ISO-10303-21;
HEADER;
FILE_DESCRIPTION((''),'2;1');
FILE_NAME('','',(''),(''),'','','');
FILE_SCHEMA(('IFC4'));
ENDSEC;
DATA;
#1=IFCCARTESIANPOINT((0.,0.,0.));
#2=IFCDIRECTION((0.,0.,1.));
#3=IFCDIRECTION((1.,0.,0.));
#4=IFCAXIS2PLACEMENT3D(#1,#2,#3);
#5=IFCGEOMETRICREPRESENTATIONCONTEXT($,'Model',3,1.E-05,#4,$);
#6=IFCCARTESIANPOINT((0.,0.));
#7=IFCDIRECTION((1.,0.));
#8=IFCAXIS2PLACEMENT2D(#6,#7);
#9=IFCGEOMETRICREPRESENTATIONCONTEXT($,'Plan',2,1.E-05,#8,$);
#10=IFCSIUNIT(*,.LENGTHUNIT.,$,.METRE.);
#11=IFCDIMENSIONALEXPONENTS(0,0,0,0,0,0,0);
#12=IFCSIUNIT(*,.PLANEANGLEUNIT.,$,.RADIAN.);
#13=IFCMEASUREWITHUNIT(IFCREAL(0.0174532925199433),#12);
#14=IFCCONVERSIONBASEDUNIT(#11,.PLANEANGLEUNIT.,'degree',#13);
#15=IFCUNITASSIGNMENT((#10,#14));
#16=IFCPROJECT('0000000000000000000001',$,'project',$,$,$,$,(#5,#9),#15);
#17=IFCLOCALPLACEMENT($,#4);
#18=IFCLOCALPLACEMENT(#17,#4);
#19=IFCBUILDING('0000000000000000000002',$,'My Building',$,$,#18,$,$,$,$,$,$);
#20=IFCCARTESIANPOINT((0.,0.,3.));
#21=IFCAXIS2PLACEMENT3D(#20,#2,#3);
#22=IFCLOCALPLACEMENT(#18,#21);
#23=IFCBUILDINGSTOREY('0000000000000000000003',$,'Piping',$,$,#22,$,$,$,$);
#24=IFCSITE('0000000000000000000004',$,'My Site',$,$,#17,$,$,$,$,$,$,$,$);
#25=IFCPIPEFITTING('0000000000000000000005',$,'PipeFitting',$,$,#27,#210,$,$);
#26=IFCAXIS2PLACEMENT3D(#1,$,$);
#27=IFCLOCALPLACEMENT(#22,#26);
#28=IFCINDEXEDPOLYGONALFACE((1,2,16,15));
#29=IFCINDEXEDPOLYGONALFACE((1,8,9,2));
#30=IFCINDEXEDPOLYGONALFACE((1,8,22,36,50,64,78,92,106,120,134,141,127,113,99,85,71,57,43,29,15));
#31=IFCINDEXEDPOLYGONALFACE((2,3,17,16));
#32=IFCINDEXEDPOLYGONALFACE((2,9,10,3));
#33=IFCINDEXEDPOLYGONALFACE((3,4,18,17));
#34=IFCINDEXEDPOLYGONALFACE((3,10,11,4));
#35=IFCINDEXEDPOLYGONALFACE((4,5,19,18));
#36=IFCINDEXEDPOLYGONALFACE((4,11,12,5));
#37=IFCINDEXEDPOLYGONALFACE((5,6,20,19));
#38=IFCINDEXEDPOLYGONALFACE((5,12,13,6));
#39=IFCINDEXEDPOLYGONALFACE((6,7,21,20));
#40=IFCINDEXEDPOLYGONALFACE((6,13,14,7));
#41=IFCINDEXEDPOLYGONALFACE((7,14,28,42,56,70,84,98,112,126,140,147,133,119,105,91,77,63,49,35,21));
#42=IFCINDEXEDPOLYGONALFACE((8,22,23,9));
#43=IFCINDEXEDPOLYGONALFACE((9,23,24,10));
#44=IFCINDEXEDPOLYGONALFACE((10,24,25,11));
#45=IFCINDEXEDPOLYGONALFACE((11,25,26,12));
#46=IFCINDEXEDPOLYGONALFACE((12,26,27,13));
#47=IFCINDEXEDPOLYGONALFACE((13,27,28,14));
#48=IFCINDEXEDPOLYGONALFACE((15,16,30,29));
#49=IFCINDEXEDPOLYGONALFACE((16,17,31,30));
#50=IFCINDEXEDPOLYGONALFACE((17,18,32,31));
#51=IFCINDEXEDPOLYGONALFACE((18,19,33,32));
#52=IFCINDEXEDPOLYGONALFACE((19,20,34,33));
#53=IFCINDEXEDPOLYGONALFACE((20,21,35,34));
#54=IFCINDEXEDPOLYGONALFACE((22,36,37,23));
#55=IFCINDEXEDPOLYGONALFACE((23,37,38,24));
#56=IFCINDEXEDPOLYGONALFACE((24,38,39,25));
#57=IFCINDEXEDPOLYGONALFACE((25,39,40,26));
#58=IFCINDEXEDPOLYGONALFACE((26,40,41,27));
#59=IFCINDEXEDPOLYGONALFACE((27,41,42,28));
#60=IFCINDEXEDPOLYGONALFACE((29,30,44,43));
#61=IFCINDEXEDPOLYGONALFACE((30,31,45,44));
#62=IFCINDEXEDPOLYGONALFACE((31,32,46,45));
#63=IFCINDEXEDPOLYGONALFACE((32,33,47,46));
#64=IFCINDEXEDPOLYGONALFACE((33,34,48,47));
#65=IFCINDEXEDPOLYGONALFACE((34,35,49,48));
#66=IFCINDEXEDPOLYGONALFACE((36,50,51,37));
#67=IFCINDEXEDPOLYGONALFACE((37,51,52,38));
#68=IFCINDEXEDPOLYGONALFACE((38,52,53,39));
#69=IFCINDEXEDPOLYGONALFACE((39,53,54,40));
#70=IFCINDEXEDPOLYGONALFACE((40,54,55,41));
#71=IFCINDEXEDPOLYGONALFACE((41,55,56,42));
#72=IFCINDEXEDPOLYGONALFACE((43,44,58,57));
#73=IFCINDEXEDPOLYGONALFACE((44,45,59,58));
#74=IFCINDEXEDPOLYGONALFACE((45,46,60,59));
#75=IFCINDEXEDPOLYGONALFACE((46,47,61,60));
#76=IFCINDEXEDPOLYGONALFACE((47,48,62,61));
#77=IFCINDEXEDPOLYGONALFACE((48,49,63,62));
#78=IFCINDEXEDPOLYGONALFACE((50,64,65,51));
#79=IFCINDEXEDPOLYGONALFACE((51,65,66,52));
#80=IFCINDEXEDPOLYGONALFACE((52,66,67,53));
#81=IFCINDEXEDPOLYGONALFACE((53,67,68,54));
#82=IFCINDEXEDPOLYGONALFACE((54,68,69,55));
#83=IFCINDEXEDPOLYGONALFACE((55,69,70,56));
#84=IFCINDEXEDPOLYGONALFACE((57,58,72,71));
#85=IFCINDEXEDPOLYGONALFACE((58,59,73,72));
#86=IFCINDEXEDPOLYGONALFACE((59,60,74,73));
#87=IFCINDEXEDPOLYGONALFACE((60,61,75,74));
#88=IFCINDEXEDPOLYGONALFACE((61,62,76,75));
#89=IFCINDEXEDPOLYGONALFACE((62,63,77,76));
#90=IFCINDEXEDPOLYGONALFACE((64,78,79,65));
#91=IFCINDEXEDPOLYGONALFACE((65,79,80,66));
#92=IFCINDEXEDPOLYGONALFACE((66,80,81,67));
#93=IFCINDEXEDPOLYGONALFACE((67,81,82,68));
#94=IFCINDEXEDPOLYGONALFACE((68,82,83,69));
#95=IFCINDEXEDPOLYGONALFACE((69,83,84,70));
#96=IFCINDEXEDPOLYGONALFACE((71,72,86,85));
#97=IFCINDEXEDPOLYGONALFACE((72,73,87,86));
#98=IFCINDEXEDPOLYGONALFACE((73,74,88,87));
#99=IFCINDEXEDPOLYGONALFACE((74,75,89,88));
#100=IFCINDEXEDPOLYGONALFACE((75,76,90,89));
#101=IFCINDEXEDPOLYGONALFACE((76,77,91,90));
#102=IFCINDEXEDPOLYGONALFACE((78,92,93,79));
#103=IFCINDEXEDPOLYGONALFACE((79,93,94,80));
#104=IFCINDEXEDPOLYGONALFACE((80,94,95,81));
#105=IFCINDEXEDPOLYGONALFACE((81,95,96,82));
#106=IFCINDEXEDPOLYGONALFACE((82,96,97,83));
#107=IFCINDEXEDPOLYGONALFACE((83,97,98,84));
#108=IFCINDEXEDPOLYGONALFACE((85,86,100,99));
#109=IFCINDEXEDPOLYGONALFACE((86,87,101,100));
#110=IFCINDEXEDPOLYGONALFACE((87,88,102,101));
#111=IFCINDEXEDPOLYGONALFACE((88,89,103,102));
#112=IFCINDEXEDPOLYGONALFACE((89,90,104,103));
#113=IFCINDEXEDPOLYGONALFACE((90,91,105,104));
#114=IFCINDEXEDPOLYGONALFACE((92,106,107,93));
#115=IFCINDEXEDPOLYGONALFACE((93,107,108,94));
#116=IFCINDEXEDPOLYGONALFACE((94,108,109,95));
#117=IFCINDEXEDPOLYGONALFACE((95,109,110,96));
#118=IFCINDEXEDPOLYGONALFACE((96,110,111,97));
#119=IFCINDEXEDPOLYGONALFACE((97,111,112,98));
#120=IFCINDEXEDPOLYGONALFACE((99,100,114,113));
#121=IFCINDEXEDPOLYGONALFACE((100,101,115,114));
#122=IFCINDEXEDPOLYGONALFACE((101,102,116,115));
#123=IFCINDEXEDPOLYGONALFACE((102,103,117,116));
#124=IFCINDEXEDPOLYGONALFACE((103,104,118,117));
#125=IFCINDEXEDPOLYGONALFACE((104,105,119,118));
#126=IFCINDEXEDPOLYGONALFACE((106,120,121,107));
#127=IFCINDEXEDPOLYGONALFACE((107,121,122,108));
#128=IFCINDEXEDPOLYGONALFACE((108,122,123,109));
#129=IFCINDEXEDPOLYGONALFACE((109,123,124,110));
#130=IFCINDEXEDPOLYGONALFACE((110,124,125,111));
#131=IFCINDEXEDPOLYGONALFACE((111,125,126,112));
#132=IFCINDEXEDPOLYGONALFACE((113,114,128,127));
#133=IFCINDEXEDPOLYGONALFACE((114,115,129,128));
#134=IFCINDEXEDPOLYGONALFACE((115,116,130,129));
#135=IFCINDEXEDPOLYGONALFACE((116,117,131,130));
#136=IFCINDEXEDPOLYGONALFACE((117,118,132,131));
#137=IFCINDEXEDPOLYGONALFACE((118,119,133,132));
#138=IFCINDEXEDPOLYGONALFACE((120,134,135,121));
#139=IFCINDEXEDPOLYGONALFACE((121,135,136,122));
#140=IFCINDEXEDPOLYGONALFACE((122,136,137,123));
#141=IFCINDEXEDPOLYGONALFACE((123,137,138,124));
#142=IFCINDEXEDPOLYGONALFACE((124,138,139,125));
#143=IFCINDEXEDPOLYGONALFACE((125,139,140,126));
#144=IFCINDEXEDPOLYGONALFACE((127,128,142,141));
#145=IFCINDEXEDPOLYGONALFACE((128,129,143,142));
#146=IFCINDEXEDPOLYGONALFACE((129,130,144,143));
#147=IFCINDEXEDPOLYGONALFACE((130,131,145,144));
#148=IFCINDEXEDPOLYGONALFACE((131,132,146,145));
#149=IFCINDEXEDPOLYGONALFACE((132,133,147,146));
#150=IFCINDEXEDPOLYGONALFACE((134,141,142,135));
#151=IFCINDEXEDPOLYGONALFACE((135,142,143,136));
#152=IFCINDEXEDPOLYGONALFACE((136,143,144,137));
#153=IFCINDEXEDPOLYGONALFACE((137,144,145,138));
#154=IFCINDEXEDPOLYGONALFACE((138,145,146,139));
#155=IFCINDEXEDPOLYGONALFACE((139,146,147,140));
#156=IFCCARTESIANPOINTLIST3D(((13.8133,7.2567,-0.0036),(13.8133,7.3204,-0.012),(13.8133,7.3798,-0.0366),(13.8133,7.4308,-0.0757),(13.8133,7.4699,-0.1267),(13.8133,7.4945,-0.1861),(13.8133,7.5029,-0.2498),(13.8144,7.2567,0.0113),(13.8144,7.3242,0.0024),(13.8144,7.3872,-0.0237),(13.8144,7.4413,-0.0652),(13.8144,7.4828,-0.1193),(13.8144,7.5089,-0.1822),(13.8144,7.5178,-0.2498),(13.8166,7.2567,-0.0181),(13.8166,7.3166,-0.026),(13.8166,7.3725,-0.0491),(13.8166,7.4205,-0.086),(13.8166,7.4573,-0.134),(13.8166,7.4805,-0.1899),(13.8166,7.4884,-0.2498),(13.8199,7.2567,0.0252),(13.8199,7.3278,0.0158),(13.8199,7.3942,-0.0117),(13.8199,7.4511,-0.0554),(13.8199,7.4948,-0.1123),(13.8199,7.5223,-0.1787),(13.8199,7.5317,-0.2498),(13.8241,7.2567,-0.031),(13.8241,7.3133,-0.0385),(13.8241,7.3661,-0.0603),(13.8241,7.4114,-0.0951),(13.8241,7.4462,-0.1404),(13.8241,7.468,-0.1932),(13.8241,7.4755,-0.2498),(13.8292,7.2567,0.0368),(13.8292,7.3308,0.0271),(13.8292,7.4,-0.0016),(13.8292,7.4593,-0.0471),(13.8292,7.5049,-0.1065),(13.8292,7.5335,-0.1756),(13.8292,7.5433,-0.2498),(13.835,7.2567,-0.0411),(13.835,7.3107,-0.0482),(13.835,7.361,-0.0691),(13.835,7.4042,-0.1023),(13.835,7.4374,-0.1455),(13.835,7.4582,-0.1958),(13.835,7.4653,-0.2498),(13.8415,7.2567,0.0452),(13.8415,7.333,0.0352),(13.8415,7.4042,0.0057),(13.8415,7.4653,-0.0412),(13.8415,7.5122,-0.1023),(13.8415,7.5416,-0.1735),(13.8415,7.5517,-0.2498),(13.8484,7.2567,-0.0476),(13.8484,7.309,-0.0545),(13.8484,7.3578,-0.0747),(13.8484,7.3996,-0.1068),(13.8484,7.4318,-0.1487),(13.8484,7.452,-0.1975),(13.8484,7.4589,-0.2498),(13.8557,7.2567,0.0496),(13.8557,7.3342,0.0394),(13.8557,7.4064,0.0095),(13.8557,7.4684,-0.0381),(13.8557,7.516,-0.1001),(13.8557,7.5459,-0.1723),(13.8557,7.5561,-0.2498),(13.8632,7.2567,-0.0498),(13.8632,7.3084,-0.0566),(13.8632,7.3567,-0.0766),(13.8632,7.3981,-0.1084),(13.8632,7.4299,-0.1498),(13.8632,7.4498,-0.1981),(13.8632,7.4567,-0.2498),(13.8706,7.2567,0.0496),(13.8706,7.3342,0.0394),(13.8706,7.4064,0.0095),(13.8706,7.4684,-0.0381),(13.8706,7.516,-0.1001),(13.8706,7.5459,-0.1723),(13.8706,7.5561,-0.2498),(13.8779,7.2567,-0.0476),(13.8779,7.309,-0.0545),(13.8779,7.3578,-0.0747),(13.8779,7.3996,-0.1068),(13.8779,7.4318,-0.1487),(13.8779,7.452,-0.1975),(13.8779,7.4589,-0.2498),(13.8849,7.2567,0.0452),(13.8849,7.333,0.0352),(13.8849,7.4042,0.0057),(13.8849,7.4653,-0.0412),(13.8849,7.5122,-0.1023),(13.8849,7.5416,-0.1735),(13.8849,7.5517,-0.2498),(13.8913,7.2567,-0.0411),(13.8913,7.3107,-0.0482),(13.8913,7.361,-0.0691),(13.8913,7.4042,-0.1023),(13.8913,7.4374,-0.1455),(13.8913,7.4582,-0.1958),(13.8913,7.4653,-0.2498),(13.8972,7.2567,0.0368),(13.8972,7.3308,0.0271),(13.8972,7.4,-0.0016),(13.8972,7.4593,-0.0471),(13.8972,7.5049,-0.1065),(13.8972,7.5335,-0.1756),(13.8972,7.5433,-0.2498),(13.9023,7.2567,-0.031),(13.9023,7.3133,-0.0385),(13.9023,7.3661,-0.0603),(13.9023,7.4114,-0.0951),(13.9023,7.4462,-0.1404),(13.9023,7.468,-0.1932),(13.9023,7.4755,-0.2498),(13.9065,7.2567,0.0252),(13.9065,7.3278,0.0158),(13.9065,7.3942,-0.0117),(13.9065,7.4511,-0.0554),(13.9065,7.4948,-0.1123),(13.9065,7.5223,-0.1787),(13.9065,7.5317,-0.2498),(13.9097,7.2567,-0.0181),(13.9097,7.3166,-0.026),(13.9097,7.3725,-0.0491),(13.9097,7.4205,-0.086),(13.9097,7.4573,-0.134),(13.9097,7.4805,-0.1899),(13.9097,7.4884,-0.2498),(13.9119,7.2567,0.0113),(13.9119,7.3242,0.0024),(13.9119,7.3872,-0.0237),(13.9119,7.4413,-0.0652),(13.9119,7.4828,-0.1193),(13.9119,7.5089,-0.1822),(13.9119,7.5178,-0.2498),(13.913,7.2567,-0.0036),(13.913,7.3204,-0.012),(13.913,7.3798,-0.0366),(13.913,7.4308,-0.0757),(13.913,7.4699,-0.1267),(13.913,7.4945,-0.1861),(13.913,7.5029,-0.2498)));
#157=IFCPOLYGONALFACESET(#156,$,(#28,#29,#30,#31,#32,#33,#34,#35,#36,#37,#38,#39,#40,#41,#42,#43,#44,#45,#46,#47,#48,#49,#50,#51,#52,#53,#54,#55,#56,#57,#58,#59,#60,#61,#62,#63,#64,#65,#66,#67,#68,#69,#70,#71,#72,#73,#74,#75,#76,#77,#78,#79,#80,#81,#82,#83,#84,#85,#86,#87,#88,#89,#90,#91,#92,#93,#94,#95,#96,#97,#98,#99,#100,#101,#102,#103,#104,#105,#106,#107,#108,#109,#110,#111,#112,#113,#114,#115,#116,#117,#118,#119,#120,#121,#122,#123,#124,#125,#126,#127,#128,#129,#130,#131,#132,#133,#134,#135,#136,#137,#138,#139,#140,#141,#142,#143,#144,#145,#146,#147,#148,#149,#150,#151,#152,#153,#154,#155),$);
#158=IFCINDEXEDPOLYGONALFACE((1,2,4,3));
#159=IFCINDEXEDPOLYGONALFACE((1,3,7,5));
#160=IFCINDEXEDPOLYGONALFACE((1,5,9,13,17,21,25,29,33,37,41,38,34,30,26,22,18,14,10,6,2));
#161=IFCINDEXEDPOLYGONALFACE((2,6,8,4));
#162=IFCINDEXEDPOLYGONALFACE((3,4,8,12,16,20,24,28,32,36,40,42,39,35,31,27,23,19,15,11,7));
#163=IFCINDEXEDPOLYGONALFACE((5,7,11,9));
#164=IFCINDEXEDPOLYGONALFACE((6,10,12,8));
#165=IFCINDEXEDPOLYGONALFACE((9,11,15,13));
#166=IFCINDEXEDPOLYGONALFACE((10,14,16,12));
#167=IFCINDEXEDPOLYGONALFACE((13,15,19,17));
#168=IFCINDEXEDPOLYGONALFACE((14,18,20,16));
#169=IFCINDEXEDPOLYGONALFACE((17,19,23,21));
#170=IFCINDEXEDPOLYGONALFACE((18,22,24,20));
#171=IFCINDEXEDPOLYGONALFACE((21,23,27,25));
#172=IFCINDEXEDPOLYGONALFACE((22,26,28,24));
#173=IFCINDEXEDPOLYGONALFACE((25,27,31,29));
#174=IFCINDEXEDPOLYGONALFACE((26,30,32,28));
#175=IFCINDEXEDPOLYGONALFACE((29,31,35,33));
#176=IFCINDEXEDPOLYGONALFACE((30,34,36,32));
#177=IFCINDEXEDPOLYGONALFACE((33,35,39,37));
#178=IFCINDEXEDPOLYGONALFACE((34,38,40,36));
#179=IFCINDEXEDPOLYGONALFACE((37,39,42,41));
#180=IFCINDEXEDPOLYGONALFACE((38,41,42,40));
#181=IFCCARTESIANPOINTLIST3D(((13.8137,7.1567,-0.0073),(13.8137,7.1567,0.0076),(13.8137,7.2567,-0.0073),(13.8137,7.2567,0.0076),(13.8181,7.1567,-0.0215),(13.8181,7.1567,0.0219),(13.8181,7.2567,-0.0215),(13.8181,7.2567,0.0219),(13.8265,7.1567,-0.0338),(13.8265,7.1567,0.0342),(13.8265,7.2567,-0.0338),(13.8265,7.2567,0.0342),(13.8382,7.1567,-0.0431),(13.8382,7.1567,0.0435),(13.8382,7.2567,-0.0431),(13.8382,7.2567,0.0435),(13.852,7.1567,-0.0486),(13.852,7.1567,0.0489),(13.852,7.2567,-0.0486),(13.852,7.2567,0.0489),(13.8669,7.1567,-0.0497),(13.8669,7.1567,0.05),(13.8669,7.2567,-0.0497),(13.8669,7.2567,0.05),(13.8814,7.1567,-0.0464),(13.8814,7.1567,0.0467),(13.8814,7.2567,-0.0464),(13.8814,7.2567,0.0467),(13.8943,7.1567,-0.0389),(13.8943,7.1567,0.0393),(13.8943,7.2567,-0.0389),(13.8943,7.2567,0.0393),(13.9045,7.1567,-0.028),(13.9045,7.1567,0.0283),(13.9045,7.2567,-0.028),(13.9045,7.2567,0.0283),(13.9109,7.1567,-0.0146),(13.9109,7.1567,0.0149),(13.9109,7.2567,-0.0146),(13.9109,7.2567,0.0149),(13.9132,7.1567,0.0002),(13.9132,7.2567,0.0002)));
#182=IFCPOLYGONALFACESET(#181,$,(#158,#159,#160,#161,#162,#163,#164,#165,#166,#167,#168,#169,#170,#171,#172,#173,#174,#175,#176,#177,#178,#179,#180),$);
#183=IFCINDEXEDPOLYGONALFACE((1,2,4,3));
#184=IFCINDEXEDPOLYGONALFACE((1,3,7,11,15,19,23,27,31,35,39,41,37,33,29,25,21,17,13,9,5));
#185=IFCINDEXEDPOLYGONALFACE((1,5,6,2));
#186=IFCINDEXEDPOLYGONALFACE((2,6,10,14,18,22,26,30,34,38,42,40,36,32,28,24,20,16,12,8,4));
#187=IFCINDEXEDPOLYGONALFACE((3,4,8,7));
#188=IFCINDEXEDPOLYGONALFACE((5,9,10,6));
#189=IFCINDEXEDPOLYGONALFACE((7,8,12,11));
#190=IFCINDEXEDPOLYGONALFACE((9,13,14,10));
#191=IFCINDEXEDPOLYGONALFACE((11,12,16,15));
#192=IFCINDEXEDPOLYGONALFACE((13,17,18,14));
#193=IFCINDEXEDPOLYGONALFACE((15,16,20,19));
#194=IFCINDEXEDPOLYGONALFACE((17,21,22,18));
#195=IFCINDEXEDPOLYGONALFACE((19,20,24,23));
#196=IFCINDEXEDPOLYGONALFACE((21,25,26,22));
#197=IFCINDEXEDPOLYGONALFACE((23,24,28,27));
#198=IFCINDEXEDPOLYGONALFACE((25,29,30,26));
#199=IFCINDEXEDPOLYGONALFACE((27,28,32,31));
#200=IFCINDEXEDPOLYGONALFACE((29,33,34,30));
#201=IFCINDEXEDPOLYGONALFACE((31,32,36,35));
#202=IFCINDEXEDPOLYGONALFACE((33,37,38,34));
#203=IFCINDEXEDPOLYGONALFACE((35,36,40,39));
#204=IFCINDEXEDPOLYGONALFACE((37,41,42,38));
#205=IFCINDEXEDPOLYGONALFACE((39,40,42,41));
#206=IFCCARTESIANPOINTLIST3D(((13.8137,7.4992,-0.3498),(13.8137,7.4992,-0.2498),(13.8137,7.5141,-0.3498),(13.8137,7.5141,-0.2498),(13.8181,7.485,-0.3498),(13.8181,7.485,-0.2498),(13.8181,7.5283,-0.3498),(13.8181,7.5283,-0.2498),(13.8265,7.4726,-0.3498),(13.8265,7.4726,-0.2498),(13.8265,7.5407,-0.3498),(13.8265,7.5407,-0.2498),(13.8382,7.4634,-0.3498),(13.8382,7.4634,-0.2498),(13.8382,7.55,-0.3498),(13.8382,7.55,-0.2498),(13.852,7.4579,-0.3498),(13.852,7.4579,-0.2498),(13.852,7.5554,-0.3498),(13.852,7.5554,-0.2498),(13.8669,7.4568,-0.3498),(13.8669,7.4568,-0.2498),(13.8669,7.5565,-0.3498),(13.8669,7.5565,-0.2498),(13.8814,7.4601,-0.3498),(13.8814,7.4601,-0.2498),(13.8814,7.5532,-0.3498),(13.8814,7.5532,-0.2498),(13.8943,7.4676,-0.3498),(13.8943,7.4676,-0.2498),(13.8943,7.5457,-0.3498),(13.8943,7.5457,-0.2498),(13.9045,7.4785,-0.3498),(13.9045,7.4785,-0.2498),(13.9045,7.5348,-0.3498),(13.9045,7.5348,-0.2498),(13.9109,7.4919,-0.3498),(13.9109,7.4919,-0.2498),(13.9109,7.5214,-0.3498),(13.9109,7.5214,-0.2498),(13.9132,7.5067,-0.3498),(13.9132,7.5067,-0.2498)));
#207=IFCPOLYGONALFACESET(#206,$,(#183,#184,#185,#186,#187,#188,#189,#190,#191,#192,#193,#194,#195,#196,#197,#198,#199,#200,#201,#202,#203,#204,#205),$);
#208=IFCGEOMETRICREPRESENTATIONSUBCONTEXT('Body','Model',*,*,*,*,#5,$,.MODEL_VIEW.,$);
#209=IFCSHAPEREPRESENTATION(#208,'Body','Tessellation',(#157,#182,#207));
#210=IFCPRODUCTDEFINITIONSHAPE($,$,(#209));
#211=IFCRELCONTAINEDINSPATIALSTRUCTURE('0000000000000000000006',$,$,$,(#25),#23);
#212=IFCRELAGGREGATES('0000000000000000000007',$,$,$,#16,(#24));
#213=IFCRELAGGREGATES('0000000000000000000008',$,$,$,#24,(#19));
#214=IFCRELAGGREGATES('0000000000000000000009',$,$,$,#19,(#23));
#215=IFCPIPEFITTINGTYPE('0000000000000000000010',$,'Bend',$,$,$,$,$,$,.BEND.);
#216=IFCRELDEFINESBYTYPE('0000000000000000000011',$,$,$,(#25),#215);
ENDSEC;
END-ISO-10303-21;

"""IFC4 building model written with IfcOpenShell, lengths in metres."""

from ifc_helpers import new_model, entity, si_unit, converted_unit, frame, origin_with_axes, origin_2d_with_axis, place, context, subcontext, project, spatial, circle, extrude, source, transform, mapped, type_object, type_shapes, element, save


model = new_model("IFC4")

# Units and contexts
model_context = context("Model", 3, precision=1e-05, world=origin_with_axes())
plan_context = context("Plan", 2, precision=1e-05, world=origin_2d_with_axis())
body_context = subcontext(model_context, "Body", "Model", "MODEL_VIEW")
ifc_project = project(units=[si_unit("LENGTHUNIT", "METRE"), converted_unit("PLANEANGLEUNIT", "degree", entity("IfcReal", 0.0174532925199433), si_unit("PLANEANGLEUNIT", "RADIAN"), dimensions=[0, 0, 0, 0, 0, 0, 0])], contexts=[model_context, plan_context])

# Site, building, storey
site_placement = place(None, origin_with_axes())
site = spatial("IfcSite", under=ifc_project, at=site_placement, Name="My Site")
building_placement = place(site_placement, origin_with_axes())
building = spatial("IfcBuilding", under=site, at=building_placement, Name="My Building")
storey_placement = place(building_placement, frame((0.0, 0.0, 3.0), z_axis=(0.0, 0.0, 1.0), x_axis=(1.0, 0.0, 0.0)))
storey = spatial("IfcBuildingStorey", under=building, at=storey_placement, Name="Piping")

# Pipe fitting
pipe_fitting_type = type_object("IfcPipeFittingType", Name="Bend", PredefinedType="BEND")
shared_shape = source(origin_with_axes(), body_context, "Body", "SolidModel", [
    entity("IfcSweptDiskSolid", entity("IfcIndexedPolyCurve", entity("IfcCartesianPointList3D", [[0.0, 0.0, -0.1], [0.0, -0.0732, -0.2768], [0.0, -0.25, -0.35]]), [entity("IfcArcIndex", [1, 2, 3])]), 0.05),
    extrude(circle(Radius=0.05), origin_with_axes(), (0.0, 0.0, -1.0), 0.1),
    extrude(circle(Radius=0.05), frame((0.0, -0.25, -0.35), z_axis=(0.0, -1.0, 0.0), x_axis=(1.0, 0.0, 0.0)), (0.0, 0.0, 1.0), 0.1),
])
type_shapes(pipe_fitting_type, [shared_shape])
for number, where, z_axis, x_axis, name in (
    (1, (13.8632, 7.1567, 0.0002), (0.0, -1.0, 0.0), (1.0, 0.0, 0.0), "PipeFitting"),
):
    element("IfcPipeFitting", number, at=place(storey_placement, frame(where, z_axis=z_axis, x_axis=x_axis)), inside=storey, type_object=pipe_fitting_type, Name=name, context=body_context, shape_type="MappedRepresentation", body=[
        mapped(shared_shape, transform((0.0, 0.0, 0.0), x_axis=(1.0, 0.0, 0.0), y_axis=(0.0, 1.0, 0.0), z_axis=(0.0, 0.0, 1.0), scale=1.0)),
    ])

save(model, "model.ifc")
